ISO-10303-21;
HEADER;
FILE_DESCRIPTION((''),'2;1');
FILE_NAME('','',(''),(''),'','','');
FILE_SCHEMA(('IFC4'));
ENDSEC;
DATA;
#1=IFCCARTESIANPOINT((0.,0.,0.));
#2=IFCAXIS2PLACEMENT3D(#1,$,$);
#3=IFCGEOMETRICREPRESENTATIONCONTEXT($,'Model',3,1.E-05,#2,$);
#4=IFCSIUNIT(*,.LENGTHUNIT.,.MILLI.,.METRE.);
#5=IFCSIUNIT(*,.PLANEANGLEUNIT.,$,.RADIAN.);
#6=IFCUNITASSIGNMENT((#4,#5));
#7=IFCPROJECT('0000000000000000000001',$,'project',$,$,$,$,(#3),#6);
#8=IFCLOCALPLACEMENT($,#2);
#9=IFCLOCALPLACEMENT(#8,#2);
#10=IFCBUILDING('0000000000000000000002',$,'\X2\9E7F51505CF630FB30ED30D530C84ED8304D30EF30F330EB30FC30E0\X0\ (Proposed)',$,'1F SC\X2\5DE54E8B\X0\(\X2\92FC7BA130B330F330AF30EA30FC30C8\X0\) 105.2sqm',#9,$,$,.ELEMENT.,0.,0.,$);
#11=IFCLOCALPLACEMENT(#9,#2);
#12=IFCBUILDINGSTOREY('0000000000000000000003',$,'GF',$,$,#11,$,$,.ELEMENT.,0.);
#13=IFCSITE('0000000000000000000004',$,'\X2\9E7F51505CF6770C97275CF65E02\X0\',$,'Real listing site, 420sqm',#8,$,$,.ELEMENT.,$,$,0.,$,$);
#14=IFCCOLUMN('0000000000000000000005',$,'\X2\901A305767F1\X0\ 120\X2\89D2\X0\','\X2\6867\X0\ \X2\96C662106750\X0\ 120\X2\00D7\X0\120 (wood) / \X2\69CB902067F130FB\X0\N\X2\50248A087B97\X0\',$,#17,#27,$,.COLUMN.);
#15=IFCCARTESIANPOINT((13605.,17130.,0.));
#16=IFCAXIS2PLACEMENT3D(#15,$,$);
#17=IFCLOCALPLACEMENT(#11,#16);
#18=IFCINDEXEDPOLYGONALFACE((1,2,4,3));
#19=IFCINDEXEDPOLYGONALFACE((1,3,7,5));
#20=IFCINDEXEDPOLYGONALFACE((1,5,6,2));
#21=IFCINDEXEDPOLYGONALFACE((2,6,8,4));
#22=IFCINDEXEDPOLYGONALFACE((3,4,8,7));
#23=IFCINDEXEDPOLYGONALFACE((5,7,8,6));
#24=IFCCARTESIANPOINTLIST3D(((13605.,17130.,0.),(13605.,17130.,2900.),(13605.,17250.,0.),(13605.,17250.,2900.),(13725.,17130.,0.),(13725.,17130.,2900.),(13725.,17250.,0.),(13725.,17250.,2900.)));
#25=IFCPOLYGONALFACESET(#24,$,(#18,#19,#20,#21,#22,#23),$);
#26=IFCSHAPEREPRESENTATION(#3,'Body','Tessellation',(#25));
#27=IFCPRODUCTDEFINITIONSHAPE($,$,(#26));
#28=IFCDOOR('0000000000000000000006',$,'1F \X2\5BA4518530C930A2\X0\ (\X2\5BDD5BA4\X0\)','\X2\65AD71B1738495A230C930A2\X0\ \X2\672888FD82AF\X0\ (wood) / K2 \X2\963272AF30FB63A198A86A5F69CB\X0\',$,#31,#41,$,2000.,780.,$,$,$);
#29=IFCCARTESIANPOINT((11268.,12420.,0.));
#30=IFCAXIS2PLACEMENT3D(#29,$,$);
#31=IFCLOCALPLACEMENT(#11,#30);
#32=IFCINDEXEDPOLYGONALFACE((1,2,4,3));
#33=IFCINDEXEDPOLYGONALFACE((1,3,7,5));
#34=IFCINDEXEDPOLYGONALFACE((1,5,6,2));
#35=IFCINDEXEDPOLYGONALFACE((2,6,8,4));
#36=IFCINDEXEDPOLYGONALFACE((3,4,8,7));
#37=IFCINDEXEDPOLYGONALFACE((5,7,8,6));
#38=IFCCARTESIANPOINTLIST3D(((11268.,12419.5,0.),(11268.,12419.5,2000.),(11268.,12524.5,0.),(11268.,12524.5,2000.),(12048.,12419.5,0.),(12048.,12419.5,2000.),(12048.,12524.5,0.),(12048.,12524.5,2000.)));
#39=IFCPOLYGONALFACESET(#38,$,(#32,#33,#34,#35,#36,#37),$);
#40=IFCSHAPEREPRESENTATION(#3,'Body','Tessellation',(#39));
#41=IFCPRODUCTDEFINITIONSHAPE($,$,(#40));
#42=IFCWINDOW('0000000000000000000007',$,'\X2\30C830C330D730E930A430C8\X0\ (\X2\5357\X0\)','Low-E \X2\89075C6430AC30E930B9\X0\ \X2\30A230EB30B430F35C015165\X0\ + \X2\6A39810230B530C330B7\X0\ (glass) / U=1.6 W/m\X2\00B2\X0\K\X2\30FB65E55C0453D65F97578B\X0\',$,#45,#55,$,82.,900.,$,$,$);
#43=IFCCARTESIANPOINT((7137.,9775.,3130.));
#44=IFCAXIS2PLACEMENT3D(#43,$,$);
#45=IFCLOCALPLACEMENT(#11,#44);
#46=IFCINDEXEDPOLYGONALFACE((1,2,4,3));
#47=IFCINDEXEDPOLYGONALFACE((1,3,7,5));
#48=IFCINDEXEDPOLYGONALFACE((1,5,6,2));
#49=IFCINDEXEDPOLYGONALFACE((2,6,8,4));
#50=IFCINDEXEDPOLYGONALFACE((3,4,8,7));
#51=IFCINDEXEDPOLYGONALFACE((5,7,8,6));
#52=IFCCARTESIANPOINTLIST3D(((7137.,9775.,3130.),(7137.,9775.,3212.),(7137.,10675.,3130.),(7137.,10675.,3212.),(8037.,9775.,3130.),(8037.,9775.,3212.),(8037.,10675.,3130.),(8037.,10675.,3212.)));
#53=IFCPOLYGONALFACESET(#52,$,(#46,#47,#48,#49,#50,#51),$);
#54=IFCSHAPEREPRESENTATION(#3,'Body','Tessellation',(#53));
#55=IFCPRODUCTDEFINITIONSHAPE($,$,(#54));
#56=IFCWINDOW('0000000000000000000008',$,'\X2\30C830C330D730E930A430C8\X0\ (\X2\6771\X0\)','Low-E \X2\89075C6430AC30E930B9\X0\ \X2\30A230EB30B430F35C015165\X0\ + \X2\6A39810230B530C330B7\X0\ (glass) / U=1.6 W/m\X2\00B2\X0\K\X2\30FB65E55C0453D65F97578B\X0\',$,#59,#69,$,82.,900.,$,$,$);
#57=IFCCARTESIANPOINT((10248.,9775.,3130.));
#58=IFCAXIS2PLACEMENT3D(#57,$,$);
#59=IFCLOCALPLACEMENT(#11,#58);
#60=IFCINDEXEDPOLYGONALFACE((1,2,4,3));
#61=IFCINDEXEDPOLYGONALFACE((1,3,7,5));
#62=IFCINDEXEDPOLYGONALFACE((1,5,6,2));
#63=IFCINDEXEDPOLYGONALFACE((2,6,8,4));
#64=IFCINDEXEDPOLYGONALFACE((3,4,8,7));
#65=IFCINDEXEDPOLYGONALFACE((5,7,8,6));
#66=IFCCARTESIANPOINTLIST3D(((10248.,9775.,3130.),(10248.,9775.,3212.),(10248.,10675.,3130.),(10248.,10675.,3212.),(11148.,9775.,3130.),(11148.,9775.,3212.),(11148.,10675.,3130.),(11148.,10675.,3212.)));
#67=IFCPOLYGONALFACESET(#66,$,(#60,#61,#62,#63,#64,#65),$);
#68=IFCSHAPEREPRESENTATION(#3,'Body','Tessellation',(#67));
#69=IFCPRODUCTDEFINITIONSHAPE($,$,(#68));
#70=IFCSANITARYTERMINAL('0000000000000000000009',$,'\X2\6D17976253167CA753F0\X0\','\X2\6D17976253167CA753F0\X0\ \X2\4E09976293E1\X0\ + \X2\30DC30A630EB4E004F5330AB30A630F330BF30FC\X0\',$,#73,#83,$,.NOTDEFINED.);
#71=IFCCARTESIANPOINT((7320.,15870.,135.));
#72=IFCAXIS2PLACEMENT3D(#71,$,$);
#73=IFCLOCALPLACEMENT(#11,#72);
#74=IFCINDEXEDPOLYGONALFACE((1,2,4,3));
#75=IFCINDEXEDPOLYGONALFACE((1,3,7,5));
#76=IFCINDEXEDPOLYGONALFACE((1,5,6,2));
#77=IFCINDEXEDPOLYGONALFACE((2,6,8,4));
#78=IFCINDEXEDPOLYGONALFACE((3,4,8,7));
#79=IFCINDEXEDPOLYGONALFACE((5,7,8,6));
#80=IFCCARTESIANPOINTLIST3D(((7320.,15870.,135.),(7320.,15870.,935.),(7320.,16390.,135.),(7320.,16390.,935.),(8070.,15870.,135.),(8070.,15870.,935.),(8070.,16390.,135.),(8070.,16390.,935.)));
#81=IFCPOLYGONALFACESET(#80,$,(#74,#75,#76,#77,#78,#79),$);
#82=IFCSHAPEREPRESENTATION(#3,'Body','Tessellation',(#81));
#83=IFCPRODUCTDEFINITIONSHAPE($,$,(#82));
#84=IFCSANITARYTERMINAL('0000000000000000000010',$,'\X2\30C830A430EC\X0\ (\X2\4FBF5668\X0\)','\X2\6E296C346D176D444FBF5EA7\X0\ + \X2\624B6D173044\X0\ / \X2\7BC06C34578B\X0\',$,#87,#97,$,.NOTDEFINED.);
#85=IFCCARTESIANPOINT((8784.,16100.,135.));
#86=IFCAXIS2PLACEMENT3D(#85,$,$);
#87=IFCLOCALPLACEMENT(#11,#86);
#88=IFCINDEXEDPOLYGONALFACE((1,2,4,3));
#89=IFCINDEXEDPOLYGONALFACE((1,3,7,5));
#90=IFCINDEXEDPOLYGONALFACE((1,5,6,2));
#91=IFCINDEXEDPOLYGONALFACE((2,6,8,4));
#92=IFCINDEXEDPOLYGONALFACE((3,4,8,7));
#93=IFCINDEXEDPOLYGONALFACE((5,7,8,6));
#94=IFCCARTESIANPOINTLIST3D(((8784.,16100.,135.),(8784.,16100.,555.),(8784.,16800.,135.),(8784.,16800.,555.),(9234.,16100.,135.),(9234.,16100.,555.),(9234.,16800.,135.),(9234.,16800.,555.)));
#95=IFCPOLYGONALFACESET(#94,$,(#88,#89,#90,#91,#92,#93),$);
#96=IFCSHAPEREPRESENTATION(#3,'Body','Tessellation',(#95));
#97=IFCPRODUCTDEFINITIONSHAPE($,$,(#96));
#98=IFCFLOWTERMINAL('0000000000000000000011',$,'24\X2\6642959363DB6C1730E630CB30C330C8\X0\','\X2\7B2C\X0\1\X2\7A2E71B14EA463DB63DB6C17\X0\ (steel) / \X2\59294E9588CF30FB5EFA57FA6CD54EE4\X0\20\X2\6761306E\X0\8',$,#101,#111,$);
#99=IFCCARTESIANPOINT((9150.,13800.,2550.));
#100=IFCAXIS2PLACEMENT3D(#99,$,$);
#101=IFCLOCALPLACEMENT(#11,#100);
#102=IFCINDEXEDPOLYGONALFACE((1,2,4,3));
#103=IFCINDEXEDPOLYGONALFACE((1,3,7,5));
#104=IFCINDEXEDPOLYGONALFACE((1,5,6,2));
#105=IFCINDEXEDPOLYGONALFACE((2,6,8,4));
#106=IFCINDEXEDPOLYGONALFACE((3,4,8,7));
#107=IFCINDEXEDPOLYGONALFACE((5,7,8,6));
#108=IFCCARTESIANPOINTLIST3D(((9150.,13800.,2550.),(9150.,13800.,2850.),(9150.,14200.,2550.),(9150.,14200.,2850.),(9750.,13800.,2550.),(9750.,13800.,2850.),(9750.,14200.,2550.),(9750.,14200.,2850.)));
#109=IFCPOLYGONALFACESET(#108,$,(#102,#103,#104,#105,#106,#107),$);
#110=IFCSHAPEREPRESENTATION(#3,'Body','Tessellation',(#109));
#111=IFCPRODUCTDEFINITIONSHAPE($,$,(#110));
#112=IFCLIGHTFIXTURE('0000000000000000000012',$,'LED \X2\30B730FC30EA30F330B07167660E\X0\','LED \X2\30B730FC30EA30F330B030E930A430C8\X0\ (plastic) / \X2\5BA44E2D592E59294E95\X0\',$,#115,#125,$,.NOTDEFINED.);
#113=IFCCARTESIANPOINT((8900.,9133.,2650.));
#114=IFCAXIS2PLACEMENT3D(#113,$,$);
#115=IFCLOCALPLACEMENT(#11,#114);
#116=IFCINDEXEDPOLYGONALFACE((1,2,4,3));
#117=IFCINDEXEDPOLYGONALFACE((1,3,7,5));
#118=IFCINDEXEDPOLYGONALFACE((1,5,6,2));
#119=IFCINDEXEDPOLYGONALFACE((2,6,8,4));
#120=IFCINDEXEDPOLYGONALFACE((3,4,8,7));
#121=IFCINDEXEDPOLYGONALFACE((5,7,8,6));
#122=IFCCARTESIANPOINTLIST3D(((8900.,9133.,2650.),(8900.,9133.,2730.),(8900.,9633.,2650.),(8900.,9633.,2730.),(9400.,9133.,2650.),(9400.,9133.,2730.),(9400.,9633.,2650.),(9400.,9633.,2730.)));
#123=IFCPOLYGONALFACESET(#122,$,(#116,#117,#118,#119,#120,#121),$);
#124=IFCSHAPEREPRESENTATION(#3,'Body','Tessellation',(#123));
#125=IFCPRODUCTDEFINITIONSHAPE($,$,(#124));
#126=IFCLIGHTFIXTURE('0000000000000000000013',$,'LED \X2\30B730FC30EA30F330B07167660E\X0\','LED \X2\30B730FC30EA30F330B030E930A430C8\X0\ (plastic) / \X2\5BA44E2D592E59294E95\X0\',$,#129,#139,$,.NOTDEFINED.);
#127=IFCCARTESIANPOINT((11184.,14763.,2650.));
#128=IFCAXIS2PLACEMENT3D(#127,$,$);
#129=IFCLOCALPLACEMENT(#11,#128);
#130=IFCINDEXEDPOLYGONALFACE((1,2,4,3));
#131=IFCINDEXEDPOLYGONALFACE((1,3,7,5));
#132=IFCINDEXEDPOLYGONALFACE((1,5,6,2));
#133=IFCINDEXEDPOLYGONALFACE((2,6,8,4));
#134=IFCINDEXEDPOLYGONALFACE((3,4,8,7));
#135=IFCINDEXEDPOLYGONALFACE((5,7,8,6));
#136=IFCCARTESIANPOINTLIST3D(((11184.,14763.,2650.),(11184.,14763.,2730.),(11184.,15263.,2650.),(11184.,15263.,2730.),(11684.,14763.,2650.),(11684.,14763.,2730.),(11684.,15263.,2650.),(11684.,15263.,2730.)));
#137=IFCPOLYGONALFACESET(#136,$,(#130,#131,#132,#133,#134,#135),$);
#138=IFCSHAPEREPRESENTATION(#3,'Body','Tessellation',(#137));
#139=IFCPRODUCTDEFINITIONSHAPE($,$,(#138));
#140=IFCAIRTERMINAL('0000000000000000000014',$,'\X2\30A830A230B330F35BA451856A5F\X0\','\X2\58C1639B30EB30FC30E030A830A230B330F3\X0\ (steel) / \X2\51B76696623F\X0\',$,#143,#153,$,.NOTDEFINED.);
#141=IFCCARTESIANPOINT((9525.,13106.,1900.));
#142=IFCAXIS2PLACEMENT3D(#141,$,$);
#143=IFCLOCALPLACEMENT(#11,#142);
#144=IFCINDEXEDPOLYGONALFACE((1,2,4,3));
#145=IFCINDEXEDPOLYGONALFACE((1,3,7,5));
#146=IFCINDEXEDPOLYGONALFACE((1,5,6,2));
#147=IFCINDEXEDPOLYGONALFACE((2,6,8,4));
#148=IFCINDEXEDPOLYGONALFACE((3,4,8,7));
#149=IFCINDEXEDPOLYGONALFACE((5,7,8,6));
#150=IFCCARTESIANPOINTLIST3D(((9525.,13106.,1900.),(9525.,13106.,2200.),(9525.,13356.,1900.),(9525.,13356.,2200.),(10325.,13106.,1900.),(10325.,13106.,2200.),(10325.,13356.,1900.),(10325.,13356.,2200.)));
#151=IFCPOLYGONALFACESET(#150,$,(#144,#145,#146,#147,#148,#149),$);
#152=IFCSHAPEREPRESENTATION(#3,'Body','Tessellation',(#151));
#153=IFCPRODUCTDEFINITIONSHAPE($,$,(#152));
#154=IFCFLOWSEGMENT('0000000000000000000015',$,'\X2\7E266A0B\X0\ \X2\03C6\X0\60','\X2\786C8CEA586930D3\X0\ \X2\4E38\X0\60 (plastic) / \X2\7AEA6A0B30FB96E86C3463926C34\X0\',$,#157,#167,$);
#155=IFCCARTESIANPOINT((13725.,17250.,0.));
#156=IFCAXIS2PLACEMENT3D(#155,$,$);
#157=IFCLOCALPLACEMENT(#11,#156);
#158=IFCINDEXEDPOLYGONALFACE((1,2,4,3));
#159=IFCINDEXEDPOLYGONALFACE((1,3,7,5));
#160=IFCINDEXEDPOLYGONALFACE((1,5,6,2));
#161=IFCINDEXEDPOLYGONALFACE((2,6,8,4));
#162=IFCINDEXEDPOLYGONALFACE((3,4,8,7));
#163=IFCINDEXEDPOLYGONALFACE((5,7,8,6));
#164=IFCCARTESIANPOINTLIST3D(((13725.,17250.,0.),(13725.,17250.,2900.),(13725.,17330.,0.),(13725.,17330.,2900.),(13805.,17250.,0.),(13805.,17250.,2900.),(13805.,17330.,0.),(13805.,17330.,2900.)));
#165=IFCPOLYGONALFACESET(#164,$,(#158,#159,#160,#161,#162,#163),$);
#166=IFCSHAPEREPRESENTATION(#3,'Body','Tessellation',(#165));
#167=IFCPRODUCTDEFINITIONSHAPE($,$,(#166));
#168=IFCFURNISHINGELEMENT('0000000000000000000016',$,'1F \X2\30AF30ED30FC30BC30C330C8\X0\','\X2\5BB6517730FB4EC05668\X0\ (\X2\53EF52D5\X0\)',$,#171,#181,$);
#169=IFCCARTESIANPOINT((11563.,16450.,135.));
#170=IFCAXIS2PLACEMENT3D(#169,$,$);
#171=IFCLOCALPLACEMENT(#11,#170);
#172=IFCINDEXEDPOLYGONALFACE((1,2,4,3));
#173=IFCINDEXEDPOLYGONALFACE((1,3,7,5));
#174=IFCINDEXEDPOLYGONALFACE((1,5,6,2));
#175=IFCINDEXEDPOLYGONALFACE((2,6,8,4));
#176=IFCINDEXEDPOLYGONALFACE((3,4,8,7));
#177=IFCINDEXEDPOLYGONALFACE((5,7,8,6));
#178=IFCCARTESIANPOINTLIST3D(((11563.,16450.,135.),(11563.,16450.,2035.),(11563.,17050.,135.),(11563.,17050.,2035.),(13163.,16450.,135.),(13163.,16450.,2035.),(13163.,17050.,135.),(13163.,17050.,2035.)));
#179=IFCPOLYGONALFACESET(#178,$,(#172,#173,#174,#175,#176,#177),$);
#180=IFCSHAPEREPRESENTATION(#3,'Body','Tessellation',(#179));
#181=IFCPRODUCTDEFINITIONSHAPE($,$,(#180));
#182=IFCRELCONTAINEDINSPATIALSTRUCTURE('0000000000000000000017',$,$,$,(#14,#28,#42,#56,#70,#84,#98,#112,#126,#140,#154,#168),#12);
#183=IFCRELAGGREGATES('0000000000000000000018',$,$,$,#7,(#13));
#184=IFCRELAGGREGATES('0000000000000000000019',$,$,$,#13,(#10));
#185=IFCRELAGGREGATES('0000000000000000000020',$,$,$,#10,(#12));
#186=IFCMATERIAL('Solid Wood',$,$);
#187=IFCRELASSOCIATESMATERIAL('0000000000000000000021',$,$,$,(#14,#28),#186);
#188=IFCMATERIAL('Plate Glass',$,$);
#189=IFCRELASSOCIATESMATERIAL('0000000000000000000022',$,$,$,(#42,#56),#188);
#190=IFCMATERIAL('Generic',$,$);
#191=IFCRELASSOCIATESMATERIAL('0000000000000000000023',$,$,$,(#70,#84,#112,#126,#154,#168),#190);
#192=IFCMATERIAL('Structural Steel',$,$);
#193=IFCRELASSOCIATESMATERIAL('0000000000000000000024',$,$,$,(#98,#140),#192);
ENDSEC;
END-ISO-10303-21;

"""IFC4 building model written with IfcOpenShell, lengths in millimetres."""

from ifc_helpers import new_model, si_unit, frame, frame_2d, origin, place, context, project, spatial, rectangle, extrude, material, element, save


model = new_model("IFC4")

# Units and contexts
model_context = context("Model", 3, precision=1e-05, world=origin())
ifc_project = project(units=[si_unit("LENGTHUNIT", "METRE", prefix="MILLI"), si_unit("PLANEANGLEUNIT", "RADIAN")], contexts=[model_context])

# Site, building, storey
site_placement = place(None, origin())
site = spatial("IfcSite", under=ifc_project, at=site_placement, Name="鹿児島県霧島市", ObjectType="Real listing site, 420sqm", CompositionType="ELEMENT", RefElevation=0.0)
building_placement = place(site_placement, origin())
building = spatial("IfcBuilding", under=site, at=building_placement, Name="鹿児島・ロフト付きワンルーム (Proposed)", ObjectType="1F SC工事(鋼管コンクリート) 105.2sqm", CompositionType="ELEMENT", ElevationOfRefHeight=0.0, ElevationOfTerrain=0.0)
storey_placement = place(building_placement, origin())
storey = spatial("IfcBuildingStorey", under=building, at=storey_placement, Name="GF", CompositionType="ELEMENT", Elevation=0.0)

# Column
ifc_material_1 = material(Name="Solid Wood")
column_1_placement = place(storey_placement, frame((13605.0, 17130.0, 0.0)))
element("IfcColumn", 1, at=column_1_placement, inside=storey, material=ifc_material_1, Name="通し柱 120角", Description="桧 集成材 120×120 (wood) / 構造柱・N値計算", PredefinedType="COLUMN", context=model_context, shape_type="SweptSolid", body=[
    extrude(rectangle(XDim=120.0, YDim=120.0, at=frame_2d((60.0, 60.0))), frame((13605.0, 17130.0, 0.0)), (0.0, 0.0, 1.0), 2900.0),
])

# Door
door_placement = place(storey_placement, frame((11268.0, 12420.0, 0.0)))
element("IfcDoor", 2, at=door_placement, inside=storey, material=ifc_material_1, Name="1F 室内ドア (寝室)", Description="断熱玄関ドア 木製芯 (wood) / K2 防犯・採風機構", OverallHeight=2000.0, OverallWidth=780.0, context=model_context, shape_type="SweptSolid", body=[
    extrude(rectangle(XDim=780.0, YDim=105.0, at=frame_2d((390.0, 52.0))), frame((11268.0, 12420.0, 0.0)), (0.0, 0.0, 1.0), 2000.0),
])

# Windows
ifc_material_2 = material(Name="Plate Glass")
window_1_placement = place(storey_placement, frame((7137.0, 9775.0, 3130.0)))
element("IfcWindow", 3, at=window_1_placement, inside=storey, material=ifc_material_2, Name="トップライト (南)", Description="Low-E 複層ガラス アルゴン封入 + 樹脂サッシ (glass) / U=1.6 W/m²K・日射取得型", OverallHeight=82.0, OverallWidth=900.0, context=model_context, shape_type="SweptSolid", body=[
    extrude(rectangle(XDim=900.0, YDim=900.0, at=frame_2d((450.0, 450.0))), frame((7137.0, 9775.0, 3130.0)), (0.0, 0.0, 1.0), 82.0),
])
window_2_placement = place(storey_placement, frame((10248.0, 9775.0, 3130.0)))
element("IfcWindow", 4, at=window_2_placement, inside=storey, material=ifc_material_2, Name="トップライト (東)", Description="Low-E 複層ガラス アルゴン封入 + 樹脂サッシ (glass) / U=1.6 W/m²K・日射取得型", OverallHeight=82.0, OverallWidth=900.0, context=model_context, shape_type="SweptSolid", body=[
    extrude(rectangle(XDim=900.0, YDim=900.0, at=frame_2d((450.0, 450.0))), frame((10248.0, 9775.0, 3130.0)), (0.0, 0.0, 1.0), 82.0),
])

# Sanitary terminals
ifc_material_3 = material(Name="Generic")
sanitary_terminal_1_placement = place(storey_placement, frame((7320.0, 15870.0, 135.0)))
element("IfcSanitaryTerminal", 5, at=sanitary_terminal_1_placement, inside=storey, material=ifc_material_3, Name="洗面化粧台", Description="洗面化粧台 三面鏡 + ボウル一体カウンター", PredefinedType="NOTDEFINED", context=model_context, shape_type="SweptSolid", body=[
    extrude(rectangle(XDim=750.0, YDim=520.0, at=frame_2d((375.0, 260.0))), frame((7320.0, 15870.0, 135.0)), (0.0, 0.0, 1.0), 800.0),
])
sanitary_terminal_2_placement = place(storey_placement, frame((8784.0, 16100.0, 135.0)))
element("IfcSanitaryTerminal", 6, at=sanitary_terminal_2_placement, inside=storey, material=ifc_material_3, Name="トイレ (便器)", Description="温水洗浄便座 + 手洗い / 節水型", PredefinedType="NOTDEFINED", context=model_context, shape_type="SweptSolid", body=[
    extrude(rectangle(XDim=450.0, YDim=700.0, at=frame_2d((225.0, 350.0))), frame((8784.0, 16100.0, 135.0)), (0.0, 0.0, 1.0), 420.0),
])

# Flow terminal
ifc_material_4 = material(Name="Structural Steel")
flow_terminal_placement = place(storey_placement, frame((9150.0, 13800.0, 2550.0)))
element("IfcFlowTerminal", 7, at=flow_terminal_placement, inside=storey, material=ifc_material_4, Name="24時間換気ユニット", Description="第1種熱交換換気 (steel) / 天井裏・建基法令20条の8", context=model_context, shape_type="SweptSolid", body=[
    extrude(rectangle(XDim=600.0, YDim=400.0, at=frame_2d((300.0, 200.0))), frame((9150.0, 13800.0, 2550.0)), (0.0, 0.0, 1.0), 300.0),
])

# Light fixtures
light_fixture_1_placement = place(storey_placement, frame((8900.0, 9133.0, 2650.0)))
element("IfcLightFixture", 8, at=light_fixture_1_placement, inside=storey, material=ifc_material_3, Name="LED シーリング照明", Description="LED シーリングライト (plastic) / 室中央天井", PredefinedType="NOTDEFINED", context=model_context, shape_type="SweptSolid", body=[
    extrude(rectangle(XDim=500.0, YDim=500.0, at=frame_2d((250.0, 250.0))), frame((8900.0, 9133.0, 2650.0)), (0.0, 0.0, 1.0), 80.0),
])
light_fixture_2_placement = place(storey_placement, frame((11184.0, 14763.0, 2650.0)))
element("IfcLightFixture", 9, at=light_fixture_2_placement, inside=storey, material=ifc_material_3, Name="LED シーリング照明", Description="LED シーリングライト (plastic) / 室中央天井", PredefinedType="NOTDEFINED", context=model_context, shape_type="SweptSolid", body=[
    extrude(rectangle(XDim=500.0, YDim=500.0, at=frame_2d((250.0, 250.0))), frame((11184.0, 14763.0, 2650.0)), (0.0, 0.0, 1.0), 80.0),
])

# Air terminal
air_terminal_placement = place(storey_placement, frame((9525.0, 13106.0, 1900.0)))
element("IfcAirTerminal", 10, at=air_terminal_placement, inside=storey, material=ifc_material_4, Name="エアコン室内機", Description="壁掛ルームエアコン (steel) / 冷暖房", PredefinedType="NOTDEFINED", context=model_context, shape_type="SweptSolid", body=[
    extrude(rectangle(XDim=800.0, YDim=250.0, at=frame_2d((400.0, 125.0))), frame((9525.0, 13106.0, 1900.0)), (0.0, 0.0, 1.0), 300.0),
])

# Flow segment
flow_segment_placement = place(storey_placement, frame((13725.0, 17250.0, 0.0)))
element("IfcFlowSegment", 11, at=flow_segment_placement, inside=storey, material=ifc_material_3, Name="縦樋 φ60", Description="硬質塩ビ 丸60 (plastic) / 竪樋・雨水排水", context=model_context, shape_type="SweptSolid", body=[
    extrude(rectangle(XDim=80.0, YDim=80.0, at=frame_2d((40.0, 40.0))), frame((13725.0, 17250.0, 0.0)), (0.0, 0.0, 1.0), 2900.0),
])

# Furnishing element
furnishing_placement = place(storey_placement, frame((11563.0, 16450.0, 135.0)))
element("IfcFurnishingElement", 12, at=furnishing_placement, inside=storey, material=ifc_material_3, Name="1F クローゼット", Description="家具・什器 (可動)", context=model_context, shape_type="SweptSolid", body=[
    extrude(rectangle(XDim=1600.0, YDim=600.0, at=frame_2d((800.0, 300.0))), frame((11563.0, 16450.0, 135.0)), (0.0, 0.0, 1.0), 1900.0),
])

save(model, "model.ifc")
